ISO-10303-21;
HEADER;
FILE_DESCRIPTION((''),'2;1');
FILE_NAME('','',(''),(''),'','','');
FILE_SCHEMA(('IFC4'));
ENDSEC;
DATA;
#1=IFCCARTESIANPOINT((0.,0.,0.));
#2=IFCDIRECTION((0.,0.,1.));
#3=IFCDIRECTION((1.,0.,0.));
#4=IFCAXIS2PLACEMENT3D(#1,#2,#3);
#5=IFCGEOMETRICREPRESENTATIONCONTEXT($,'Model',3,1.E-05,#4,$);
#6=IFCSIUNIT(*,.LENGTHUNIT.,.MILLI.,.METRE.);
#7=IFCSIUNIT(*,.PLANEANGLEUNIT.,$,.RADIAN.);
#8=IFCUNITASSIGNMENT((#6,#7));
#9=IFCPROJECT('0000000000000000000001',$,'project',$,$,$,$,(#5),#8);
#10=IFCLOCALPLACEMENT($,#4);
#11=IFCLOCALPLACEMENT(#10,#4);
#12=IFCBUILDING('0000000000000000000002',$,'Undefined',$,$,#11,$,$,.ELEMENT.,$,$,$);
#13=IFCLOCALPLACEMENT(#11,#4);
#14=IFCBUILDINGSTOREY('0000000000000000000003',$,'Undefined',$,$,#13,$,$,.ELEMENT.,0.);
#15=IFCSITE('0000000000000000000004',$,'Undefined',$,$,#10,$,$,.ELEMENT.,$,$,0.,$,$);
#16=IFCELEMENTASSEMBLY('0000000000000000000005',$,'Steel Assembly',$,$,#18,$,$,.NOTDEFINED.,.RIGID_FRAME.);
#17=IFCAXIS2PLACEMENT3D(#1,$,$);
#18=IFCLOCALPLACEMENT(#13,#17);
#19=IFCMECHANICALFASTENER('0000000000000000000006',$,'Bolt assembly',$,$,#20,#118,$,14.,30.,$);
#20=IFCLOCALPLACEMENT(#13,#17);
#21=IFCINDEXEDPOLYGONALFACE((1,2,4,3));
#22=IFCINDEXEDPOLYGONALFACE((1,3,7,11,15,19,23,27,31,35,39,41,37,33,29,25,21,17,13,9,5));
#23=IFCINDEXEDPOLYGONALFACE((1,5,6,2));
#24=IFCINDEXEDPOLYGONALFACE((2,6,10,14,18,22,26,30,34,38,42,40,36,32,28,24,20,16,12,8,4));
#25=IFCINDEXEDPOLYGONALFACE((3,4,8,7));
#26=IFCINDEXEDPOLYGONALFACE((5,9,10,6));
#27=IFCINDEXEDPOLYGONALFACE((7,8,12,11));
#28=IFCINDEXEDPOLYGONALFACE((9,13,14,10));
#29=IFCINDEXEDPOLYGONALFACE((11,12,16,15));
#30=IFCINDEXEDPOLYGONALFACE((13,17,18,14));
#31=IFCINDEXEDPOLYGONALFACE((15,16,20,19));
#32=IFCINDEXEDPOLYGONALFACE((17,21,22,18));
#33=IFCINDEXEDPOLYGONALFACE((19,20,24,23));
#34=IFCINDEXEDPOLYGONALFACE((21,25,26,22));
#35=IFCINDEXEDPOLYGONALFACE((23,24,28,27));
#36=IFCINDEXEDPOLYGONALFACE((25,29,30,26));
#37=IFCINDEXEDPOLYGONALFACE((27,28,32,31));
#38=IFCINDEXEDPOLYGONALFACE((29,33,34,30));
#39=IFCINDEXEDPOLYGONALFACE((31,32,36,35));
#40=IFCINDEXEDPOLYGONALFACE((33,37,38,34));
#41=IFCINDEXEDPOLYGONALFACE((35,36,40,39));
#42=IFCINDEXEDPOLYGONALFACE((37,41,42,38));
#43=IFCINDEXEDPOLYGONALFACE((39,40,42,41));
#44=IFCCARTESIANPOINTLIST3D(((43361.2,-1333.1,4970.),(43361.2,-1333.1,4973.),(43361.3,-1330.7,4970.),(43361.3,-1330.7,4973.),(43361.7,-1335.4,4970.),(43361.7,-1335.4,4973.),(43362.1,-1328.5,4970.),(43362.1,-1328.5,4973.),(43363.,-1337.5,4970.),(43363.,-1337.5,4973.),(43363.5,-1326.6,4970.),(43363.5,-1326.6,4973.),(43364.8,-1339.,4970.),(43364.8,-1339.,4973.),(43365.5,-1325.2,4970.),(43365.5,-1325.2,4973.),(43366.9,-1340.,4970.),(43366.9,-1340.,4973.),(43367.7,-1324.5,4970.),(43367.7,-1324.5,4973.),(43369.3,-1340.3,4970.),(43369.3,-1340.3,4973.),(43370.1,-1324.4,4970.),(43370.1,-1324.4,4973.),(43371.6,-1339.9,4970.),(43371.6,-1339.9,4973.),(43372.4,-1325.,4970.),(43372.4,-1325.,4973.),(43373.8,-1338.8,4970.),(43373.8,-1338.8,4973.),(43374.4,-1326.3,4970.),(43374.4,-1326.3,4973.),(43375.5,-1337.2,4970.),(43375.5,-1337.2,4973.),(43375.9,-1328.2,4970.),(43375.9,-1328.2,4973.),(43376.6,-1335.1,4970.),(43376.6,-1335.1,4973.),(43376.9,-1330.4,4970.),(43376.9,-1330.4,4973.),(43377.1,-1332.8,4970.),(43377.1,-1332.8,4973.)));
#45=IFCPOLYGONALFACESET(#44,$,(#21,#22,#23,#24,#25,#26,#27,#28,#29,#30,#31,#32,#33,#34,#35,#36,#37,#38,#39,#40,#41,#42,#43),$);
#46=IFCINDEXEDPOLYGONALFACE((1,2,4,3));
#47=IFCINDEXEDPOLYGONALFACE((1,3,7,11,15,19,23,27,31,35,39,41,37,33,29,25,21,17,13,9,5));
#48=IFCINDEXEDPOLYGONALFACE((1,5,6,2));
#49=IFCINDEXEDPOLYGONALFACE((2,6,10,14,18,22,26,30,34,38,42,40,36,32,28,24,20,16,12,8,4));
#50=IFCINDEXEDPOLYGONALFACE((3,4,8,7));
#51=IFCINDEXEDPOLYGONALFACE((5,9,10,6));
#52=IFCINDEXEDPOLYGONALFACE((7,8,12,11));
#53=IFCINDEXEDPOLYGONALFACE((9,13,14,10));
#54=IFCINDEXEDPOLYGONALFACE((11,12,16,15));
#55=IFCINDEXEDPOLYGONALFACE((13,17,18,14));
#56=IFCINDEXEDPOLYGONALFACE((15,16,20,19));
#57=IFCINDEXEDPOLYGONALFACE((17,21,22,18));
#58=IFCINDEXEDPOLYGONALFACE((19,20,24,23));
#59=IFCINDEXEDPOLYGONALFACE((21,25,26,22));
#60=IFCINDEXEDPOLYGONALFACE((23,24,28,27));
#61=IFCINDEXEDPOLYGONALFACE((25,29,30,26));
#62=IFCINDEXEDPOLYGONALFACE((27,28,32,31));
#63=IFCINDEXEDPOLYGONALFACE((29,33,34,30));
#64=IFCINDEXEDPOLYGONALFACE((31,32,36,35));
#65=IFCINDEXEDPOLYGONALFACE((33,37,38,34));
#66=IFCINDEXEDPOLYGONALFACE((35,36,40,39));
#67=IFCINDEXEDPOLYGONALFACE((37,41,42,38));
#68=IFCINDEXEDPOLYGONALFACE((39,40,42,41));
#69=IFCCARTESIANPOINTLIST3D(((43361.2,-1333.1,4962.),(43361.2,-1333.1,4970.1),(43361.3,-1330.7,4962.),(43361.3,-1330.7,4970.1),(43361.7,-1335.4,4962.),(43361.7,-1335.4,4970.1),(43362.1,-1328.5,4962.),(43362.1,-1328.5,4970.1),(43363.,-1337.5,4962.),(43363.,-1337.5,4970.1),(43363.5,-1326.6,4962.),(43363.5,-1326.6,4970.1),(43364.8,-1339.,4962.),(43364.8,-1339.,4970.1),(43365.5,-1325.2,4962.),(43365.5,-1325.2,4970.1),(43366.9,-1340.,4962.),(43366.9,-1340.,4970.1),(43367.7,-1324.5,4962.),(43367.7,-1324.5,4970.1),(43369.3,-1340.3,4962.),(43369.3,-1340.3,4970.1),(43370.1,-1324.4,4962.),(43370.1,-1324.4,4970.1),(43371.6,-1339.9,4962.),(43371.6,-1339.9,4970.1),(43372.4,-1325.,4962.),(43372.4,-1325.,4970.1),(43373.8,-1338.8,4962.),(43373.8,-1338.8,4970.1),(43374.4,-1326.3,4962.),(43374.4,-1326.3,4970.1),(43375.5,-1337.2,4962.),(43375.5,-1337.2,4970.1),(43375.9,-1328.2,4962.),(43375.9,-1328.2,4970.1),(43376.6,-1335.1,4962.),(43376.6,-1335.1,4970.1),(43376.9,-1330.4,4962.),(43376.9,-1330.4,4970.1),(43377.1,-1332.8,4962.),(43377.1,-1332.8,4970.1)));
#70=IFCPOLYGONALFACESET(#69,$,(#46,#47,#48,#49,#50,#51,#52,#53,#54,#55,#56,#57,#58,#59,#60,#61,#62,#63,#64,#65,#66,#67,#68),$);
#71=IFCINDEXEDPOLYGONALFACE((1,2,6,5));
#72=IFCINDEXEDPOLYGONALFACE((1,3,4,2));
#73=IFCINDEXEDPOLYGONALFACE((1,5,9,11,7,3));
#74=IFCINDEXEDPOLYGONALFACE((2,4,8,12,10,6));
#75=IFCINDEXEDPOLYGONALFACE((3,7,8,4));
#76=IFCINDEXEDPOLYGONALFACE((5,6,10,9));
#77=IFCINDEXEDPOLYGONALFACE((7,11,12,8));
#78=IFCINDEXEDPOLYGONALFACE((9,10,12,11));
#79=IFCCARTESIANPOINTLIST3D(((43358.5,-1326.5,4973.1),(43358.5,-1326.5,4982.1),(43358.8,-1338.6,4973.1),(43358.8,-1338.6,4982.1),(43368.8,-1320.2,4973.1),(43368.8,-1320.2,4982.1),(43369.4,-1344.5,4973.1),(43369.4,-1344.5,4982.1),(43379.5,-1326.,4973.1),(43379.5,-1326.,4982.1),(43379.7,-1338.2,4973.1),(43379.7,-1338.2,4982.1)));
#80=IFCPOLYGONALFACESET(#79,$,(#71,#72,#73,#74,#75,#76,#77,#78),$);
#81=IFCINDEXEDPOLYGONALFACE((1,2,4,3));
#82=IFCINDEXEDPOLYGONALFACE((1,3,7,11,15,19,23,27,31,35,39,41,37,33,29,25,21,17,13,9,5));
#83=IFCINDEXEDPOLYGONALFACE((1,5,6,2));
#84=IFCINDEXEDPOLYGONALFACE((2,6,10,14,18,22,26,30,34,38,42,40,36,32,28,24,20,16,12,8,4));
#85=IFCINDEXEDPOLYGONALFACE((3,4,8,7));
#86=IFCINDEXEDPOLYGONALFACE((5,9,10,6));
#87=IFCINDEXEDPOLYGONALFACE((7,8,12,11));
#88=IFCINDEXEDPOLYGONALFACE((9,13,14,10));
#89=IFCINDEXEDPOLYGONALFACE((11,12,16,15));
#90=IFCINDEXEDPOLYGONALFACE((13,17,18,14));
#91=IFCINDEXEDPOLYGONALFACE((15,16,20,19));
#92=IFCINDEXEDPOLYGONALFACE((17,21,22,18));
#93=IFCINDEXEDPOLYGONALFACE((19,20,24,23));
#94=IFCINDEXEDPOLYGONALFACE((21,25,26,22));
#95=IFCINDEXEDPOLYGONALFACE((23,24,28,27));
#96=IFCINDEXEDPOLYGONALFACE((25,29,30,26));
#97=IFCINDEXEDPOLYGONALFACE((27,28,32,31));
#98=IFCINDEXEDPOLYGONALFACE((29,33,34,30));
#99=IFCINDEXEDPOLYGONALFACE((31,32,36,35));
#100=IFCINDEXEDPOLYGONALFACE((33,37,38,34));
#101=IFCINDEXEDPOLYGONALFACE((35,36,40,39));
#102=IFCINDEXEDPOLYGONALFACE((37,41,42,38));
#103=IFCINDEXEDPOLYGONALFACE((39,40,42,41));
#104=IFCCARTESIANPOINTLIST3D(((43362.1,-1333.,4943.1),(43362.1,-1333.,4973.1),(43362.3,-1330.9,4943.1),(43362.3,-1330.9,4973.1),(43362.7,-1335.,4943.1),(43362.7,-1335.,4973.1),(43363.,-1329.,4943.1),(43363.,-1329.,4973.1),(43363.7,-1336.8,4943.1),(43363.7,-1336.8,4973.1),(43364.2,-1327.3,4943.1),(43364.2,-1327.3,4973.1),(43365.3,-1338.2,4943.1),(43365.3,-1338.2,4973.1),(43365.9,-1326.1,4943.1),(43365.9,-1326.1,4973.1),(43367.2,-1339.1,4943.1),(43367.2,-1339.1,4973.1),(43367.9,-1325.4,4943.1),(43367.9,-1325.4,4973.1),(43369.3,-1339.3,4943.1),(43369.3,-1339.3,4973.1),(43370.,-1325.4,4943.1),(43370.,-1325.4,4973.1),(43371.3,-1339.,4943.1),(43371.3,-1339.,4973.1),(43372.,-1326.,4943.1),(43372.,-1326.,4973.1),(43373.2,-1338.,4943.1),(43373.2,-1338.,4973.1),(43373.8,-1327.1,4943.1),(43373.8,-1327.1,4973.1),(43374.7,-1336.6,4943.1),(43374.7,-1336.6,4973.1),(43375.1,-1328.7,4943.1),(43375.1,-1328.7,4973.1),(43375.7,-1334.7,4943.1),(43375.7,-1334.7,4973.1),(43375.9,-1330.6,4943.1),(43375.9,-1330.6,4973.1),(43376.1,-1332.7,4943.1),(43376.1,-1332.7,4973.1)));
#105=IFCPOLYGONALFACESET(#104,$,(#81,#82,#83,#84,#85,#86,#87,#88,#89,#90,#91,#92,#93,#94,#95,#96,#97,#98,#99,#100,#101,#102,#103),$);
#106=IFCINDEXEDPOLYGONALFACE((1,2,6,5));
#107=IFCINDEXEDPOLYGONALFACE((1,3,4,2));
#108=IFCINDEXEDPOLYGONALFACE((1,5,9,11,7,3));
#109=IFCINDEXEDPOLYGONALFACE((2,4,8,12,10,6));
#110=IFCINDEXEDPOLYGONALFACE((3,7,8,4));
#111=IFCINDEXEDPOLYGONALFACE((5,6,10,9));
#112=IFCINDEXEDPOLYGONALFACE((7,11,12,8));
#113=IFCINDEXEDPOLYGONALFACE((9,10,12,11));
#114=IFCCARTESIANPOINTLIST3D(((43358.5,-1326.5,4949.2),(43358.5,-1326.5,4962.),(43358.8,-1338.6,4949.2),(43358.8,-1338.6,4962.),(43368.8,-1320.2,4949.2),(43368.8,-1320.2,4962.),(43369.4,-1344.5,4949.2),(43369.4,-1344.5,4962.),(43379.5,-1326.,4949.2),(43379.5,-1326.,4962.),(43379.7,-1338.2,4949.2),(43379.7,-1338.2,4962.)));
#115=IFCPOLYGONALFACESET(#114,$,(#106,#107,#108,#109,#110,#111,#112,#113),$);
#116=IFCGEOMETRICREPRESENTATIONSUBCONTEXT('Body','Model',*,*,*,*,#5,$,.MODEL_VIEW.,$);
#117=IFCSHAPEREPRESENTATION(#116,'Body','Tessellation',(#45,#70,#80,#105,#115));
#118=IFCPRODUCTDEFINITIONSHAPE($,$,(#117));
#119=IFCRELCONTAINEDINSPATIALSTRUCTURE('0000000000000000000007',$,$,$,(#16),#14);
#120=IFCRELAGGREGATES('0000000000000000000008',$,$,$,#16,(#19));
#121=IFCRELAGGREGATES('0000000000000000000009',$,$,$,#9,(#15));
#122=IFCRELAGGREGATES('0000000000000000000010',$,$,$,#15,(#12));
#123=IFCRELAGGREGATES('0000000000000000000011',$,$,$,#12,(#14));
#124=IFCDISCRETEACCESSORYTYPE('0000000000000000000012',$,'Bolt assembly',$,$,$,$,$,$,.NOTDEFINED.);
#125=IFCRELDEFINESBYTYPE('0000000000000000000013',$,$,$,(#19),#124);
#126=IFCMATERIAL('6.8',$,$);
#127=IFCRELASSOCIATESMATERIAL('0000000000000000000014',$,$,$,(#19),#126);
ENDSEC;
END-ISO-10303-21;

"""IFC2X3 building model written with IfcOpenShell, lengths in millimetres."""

from ifc_helpers import new_model, si_unit, frame, origin_with_axes, origin_2d_with_axis, place, context, subcontext, project, spatial, polyline, circle, outline, extrude, source, transform, mapped, material, type_object, element, aggregate, save


model = new_model("IFC2X3")

# Units and contexts
model_context = context("Model", 3, precision=1e-05, world=origin_with_axes())
body_context = subcontext(model_context, "Body", "Model", "MODEL_VIEW")
ifc_project = project(units=[si_unit("LENGTHUNIT", "METRE", prefix="MILLI"), si_unit("PLANEANGLEUNIT", "RADIAN")], contexts=[model_context])

# Site, building, storey
site_placement = place(None, origin_with_axes())
site = spatial("IfcSite", under=ifc_project, at=site_placement, Name="Undefined", CompositionType="ELEMENT", RefElevation=0.0)
building_placement = place(site_placement, origin_with_axes())
building = spatial("IfcBuilding", under=site, at=building_placement, Name="Undefined", CompositionType="ELEMENT")
storey_placement = place(building_placement, origin_with_axes())
storey = spatial("IfcBuildingStorey", under=building, at=storey_placement, Name="Undefined", CompositionType="ELEMENT", Elevation=0.0)

# Element assembly
assembly_1_placement = place(storey_placement, origin_with_axes())
assembly_1 = element("IfcElementAssembly", 1, at=assembly_1_placement, inside=storey, Name="Steel Assembly", AssemblyPlace="NOTDEFINED", PredefinedType="RIGID_FRAME")

# Mechanical fastener
ifc_material_1 = material(Name="6.8")
discrete_accessory_type_1 = type_object("IfcDiscreteAccessoryType", Name="Bolt assembly")
shared_shape_1 = source(origin_with_axes(), body_context, "Body", "SweptSolid", [
    extrude(circle(Radius=8.0, at=origin_2d_with_axis()), frame((0.0, -3.0, 0.0), z_axis=(0.0, 1.0, 0.0), x_axis=(1.0, 0.0, 0.0)), (0.0, 0.0, 1.0), 3.0),
    extrude(circle(Radius=8.0, at=origin_2d_with_axis()), frame((0.0, -0.1, 0.0), z_axis=(0.0, 1.0, 0.0), x_axis=(1.0, 0.0, 0.0)), (0.0, 0.0, 1.0), 8.1),
    extrude(outline(polyline([(12.1, 0.0), (6.1, 10.5), (-6.1, 10.5), (-12.1, 0.0), (-6.1, -10.5), (6.1, -10.5), (12.1, 0.0)])), frame((0.0, -12.1, 0.0), z_axis=(0.0, 1.0, 0.0), x_axis=(1.0, 0.0, 0.0)), (0.0, 0.0, 1.0), 9.0),
    extrude(circle(Radius=7.0, at=origin_2d_with_axis()), frame((0.0, -3.1, 0.0), z_axis=(0.0, 1.0, 0.0), x_axis=(1.0, 0.0, 0.0)), (0.0, 0.0, 1.0), 30.0),
    extrude(outline(polyline([(12.1, 0.0), (6.1, 10.5), (-6.1, 10.5), (-12.1, 0.0), (-6.1, -10.5), (6.1, -10.5), (12.1, 0.0)])), frame((0.0, 8.0, 0.0), z_axis=(0.0, 1.0, 0.0), x_axis=(1.0, 0.0, 0.0)), (0.0, 0.0, 1.0), 12.8),
])
mechanical_fastener_1_placement = place(assembly_1_placement, frame((43369.1, -1332.3, 4970.0), z_axis=(0.999745, 0.022588, 0.0), x_axis=(0.022588, -0.999745, 0.000001)))
mechanical_fastener_1 = element("IfcMechanicalFastener", 2, at=mechanical_fastener_1_placement, type_object=discrete_accessory_type_1, material=ifc_material_1, Name="Bolt assembly", NominalDiameter=14.0, NominalLength=30.0, context=body_context, shape_type="MappedRepresentation", body=[
    mapped(shared_shape_1, transform((0.0, 0.0, 0.0))),
])

aggregate(assembly_1, [mechanical_fastener_1])

save(model, "model.ifc")
